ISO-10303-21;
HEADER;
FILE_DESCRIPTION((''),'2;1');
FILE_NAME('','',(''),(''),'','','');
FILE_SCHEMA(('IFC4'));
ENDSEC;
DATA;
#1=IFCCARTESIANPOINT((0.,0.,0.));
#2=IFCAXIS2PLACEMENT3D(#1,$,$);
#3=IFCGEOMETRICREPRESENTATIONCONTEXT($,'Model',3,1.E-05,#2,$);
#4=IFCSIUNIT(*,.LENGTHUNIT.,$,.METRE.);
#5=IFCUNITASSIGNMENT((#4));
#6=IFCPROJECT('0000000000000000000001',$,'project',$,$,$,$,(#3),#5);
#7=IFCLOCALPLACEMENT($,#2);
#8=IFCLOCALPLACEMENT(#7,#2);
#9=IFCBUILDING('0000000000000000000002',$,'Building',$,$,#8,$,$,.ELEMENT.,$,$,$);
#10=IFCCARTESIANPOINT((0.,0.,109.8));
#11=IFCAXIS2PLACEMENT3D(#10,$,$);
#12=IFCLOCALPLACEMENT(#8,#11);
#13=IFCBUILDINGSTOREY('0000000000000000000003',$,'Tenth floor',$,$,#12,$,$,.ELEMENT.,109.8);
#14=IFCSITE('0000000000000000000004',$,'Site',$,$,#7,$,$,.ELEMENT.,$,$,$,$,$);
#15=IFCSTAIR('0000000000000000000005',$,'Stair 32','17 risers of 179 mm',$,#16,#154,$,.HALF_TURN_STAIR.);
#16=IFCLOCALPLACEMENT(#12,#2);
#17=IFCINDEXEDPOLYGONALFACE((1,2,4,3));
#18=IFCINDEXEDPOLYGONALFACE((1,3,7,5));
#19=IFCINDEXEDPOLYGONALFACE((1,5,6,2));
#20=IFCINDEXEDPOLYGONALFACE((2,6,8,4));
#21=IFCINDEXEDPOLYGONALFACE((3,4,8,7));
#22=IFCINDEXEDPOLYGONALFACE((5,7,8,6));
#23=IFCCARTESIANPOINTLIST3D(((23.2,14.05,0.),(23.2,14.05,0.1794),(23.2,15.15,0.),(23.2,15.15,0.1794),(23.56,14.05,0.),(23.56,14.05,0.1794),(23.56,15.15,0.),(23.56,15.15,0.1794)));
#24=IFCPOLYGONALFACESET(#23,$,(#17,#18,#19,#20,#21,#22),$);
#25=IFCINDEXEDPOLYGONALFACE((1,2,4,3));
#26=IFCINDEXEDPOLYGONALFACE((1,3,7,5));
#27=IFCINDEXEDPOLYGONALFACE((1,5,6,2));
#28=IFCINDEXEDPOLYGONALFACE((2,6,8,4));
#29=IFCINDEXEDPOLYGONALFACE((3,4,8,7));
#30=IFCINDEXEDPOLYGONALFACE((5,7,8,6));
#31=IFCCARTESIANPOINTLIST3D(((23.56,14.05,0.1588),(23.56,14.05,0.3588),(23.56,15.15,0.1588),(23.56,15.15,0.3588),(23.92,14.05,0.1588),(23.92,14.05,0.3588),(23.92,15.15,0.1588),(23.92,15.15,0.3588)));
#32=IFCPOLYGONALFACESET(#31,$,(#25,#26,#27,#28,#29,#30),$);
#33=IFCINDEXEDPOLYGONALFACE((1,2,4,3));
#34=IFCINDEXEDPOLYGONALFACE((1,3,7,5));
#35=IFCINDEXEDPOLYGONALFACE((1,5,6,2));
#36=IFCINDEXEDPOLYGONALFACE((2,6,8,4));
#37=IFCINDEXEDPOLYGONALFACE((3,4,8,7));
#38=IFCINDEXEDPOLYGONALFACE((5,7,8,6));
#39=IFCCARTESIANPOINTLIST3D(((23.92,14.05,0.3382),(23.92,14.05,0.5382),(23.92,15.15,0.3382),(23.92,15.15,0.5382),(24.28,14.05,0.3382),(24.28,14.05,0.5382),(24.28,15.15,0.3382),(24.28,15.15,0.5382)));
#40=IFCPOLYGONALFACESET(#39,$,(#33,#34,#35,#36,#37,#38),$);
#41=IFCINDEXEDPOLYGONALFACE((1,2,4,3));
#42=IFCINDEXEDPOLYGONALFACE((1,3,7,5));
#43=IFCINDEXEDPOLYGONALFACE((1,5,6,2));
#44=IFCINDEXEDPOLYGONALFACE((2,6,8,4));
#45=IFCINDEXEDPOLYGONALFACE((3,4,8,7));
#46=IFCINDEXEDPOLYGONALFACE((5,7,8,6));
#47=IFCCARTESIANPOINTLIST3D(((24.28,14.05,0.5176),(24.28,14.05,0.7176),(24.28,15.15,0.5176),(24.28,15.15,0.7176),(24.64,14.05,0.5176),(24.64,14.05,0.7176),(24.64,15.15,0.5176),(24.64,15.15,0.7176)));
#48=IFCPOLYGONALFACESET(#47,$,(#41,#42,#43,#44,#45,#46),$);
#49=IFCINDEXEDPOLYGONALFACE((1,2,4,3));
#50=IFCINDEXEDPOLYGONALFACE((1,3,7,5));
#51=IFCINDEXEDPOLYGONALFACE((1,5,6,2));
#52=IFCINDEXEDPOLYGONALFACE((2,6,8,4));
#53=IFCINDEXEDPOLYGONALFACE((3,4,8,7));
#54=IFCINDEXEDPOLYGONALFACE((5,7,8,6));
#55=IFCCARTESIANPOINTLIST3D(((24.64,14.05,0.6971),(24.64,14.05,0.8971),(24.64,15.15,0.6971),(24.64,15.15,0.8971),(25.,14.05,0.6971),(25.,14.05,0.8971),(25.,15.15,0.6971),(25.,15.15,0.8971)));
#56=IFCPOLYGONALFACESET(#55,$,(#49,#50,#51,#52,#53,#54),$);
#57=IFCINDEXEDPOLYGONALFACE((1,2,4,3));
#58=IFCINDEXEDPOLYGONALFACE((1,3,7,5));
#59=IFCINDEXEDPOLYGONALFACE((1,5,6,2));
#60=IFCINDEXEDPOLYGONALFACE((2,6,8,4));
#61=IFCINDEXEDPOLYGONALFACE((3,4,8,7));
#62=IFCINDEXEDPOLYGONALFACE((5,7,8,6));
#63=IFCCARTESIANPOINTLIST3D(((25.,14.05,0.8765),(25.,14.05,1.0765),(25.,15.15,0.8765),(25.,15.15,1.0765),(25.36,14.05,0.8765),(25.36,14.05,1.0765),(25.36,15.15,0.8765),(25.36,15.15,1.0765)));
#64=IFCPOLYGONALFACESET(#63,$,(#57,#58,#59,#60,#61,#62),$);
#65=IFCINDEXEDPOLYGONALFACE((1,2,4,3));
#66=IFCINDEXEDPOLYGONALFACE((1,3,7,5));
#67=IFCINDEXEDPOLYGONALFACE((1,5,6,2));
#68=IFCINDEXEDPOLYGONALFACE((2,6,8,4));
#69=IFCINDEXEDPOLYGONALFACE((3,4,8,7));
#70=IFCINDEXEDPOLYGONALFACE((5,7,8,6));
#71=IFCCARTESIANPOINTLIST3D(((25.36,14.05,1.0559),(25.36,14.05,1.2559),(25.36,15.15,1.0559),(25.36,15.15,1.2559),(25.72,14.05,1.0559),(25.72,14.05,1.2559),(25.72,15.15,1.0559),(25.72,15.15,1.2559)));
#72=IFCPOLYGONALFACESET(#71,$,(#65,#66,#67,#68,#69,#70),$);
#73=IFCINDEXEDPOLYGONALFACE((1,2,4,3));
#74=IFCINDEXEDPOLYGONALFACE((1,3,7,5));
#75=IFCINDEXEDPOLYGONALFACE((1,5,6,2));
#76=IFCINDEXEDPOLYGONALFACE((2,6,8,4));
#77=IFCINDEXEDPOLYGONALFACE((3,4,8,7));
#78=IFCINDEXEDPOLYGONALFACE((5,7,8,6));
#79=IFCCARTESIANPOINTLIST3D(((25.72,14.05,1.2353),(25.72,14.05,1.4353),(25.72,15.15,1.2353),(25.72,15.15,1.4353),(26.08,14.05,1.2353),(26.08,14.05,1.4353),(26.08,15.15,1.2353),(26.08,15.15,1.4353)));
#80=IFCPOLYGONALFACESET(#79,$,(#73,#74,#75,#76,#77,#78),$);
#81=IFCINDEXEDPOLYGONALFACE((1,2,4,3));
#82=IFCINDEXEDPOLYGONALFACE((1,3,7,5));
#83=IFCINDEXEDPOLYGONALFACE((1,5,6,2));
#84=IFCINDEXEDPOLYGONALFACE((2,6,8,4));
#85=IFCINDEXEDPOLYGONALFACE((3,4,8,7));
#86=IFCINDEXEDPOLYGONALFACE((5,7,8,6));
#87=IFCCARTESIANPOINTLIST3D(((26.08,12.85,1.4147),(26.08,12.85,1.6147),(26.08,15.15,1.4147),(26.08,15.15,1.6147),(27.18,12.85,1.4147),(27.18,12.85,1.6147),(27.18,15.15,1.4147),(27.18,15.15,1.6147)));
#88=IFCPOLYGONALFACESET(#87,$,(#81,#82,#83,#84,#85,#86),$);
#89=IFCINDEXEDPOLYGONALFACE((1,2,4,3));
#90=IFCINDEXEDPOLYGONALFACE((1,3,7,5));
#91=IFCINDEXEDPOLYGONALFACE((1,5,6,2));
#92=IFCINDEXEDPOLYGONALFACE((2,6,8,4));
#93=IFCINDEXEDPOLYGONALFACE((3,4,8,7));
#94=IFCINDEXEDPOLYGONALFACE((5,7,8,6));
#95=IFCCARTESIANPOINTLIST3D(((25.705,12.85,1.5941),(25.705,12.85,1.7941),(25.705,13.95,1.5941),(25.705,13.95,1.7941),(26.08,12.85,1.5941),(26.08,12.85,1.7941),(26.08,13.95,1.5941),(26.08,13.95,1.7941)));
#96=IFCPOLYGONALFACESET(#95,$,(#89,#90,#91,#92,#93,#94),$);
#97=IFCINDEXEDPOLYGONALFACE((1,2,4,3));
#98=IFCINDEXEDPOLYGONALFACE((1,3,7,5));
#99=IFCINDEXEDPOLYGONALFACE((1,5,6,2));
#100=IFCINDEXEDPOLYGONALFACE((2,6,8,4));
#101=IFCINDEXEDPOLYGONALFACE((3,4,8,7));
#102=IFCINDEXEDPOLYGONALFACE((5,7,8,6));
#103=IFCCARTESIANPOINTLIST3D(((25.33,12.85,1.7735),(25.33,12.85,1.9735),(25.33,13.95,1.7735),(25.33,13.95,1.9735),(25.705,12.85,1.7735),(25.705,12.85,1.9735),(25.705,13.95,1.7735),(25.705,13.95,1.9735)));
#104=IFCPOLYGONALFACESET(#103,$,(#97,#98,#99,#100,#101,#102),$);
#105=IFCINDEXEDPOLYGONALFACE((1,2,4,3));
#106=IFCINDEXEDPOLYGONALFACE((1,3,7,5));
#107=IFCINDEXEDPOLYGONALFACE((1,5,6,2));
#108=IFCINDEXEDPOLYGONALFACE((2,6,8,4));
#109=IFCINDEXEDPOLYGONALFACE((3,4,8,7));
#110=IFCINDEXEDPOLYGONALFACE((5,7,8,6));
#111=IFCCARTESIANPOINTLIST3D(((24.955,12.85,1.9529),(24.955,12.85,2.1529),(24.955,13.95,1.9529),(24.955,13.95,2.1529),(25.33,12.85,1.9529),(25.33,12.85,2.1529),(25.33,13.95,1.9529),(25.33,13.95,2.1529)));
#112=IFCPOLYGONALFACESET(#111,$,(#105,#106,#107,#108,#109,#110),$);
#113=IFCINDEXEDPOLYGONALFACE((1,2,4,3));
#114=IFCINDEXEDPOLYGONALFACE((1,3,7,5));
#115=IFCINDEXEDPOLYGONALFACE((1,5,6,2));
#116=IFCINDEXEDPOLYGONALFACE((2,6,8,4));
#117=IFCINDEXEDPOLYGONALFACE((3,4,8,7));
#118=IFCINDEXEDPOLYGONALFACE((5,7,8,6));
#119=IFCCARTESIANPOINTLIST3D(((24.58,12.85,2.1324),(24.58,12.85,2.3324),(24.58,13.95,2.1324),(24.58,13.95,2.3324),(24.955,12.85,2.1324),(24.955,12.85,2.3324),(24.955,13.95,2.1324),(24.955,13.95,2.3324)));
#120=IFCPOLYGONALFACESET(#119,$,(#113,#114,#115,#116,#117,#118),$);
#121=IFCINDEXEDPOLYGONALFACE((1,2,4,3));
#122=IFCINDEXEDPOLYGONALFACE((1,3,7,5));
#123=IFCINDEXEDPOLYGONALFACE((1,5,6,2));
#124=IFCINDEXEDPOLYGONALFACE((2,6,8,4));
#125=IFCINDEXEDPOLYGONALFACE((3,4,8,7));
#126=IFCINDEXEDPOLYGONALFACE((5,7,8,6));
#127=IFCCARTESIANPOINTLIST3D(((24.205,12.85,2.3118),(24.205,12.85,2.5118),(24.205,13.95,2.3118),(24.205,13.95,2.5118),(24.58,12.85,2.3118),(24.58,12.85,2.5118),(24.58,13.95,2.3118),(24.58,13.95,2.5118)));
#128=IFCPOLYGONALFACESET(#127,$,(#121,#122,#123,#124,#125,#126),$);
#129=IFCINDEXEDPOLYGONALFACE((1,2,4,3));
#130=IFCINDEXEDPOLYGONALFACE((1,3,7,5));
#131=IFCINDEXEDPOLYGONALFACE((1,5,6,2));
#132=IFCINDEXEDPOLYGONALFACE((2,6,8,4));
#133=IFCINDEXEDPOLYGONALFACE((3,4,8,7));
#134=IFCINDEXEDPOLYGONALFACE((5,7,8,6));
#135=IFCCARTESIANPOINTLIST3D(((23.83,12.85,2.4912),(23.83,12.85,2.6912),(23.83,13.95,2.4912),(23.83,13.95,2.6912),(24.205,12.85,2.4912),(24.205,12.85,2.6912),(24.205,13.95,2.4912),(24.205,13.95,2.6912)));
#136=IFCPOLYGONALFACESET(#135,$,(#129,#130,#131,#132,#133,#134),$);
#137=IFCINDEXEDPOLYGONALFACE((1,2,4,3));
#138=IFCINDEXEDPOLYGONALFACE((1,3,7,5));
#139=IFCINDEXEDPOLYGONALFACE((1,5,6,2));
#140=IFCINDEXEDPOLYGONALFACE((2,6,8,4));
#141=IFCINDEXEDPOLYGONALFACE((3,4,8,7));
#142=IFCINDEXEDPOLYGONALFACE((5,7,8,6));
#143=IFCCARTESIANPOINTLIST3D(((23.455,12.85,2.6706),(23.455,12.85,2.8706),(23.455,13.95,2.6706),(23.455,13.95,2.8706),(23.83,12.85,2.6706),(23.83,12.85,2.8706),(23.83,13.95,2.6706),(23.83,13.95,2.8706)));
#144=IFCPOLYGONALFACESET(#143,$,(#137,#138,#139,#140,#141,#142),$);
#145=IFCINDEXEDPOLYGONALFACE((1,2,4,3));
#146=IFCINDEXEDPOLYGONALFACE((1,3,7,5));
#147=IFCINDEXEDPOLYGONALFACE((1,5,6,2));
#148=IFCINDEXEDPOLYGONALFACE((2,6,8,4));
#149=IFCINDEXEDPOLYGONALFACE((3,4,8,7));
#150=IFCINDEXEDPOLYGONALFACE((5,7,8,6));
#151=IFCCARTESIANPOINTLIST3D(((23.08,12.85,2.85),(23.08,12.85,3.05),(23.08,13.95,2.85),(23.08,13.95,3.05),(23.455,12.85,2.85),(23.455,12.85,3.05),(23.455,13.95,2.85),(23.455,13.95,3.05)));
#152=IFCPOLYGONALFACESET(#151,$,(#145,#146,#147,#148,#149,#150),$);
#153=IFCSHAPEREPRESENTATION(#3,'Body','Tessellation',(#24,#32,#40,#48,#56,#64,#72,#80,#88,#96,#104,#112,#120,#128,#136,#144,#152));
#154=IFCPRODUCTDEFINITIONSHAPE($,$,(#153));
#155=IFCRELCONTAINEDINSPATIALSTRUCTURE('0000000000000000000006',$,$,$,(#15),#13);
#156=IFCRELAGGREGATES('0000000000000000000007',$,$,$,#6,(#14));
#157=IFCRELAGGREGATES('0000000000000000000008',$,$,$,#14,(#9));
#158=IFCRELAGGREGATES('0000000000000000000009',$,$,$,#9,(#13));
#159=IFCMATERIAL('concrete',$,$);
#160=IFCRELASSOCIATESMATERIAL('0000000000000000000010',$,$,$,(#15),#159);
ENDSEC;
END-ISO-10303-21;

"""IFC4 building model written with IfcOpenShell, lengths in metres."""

from ifc_helpers import new_model, si_unit, frame, origin, place, context, project, spatial, polyline, outline, extrude, material, element, save


model = new_model("IFC4")

# Units and contexts
model_context = context("Model", 3, precision=1e-05, world=origin())
ifc_project = project(units=[si_unit("LENGTHUNIT", "METRE")], contexts=[model_context])

# Site, building, storey
site_placement = place(None, origin())
site = spatial("IfcSite", under=ifc_project, at=site_placement, Name="Site", CompositionType="ELEMENT")
building_placement = place(site_placement, origin())
building = spatial("IfcBuilding", under=site, at=building_placement, Name="Building", CompositionType="ELEMENT")
storey_placement = place(building_placement, frame((0.0, 0.0, 109.8)))
storey = spatial("IfcBuildingStorey", under=building, at=storey_placement, Name="Tenth floor", CompositionType="ELEMENT", Elevation=109.8)

# Shared definitions
ifc_material = material(Name="concrete")

# Stair
stair_placement = place(storey_placement, frame((23.2, 14.6, 0.0), z_axis=(0.0, 0.0, 1.0), x_axis=(1.0, 0.0, 0.0)))
element("IfcStair", 1, at=stair_placement, inside=storey, material=ifc_material, Name="Stair 32", Description="17 risers of 179 mm", PredefinedType="HALF_TURN_STAIR", context=model_context, shape_type="SweptSolid", body=[
    extrude(outline(polyline([(0.0, -0.55), (0.36, -0.55), (0.36, 0.55), (0.0, 0.55), (0.0, -0.55)])), origin(), (0.0, 0.0, 1.0), 0.1794),
    extrude(outline(polyline([(0.36, -0.55), (0.72, -0.55), (0.72, 0.55), (0.36, 0.55), (0.36, -0.55)])), frame((0.0, 0.0, 0.1588)), (0.0, 0.0, 1.0), 0.2),
    extrude(outline(polyline([(0.72, -0.55), (1.08, -0.55), (1.08, 0.55), (0.72, 0.55), (0.72, -0.55)])), frame((0.0, 0.0, 0.3382)), (0.0, 0.0, 1.0), 0.2),
    extrude(outline(polyline([(1.08, -0.55), (1.44, -0.55), (1.44, 0.55), (1.08, 0.55), (1.08, -0.55)])), frame((0.0, 0.0, 0.5176)), (0.0, 0.0, 1.0), 0.2),
    extrude(outline(polyline([(1.44, -0.55), (1.8, -0.55), (1.8, 0.55), (1.44, 0.55), (1.44, -0.55)])), frame((0.0, 0.0, 0.6971)), (0.0, 0.0, 1.0), 0.2),
    extrude(outline(polyline([(1.8, -0.55), (2.16, -0.55), (2.16, 0.55), (1.8, 0.55), (1.8, -0.55)])), frame((0.0, 0.0, 0.8765)), (0.0, 0.0, 1.0), 0.2),
    extrude(outline(polyline([(2.16, -0.55), (2.52, -0.55), (2.52, 0.55), (2.16, 0.55), (2.16, -0.55)])), frame((0.0, 0.0, 1.0559)), (0.0, 0.0, 1.0), 0.2),
    extrude(outline(polyline([(2.52, -0.55), (2.88, -0.55), (2.88, 0.55), (2.52, 0.55), (2.52, -0.55)])), frame((0.0, 0.0, 1.2353)), (0.0, 0.0, 1.0), 0.2),
    extrude(outline(polyline([(2.88, -1.75), (3.98, -1.75), (3.98, 0.55), (2.88, 0.55), (2.88, -1.75)])), frame((0.0, 0.0, 1.4147)), (0.0, 0.0, 1.0), 0.2),
    extrude(outline(polyline([(2.505, -1.75), (2.88, -1.75), (2.88, -0.65), (2.505, -0.65), (2.505, -1.75)])), frame((0.0, 0.0, 1.5941)), (0.0, 0.0, 1.0), 0.2),
    extrude(outline(polyline([(2.13, -1.75), (2.505, -1.75), (2.505, -0.65), (2.13, -0.65), (2.13, -1.75)])), frame((0.0, 0.0, 1.7735)), (0.0, 0.0, 1.0), 0.2),
    extrude(outline(polyline([(1.755, -1.75), (2.13, -1.75), (2.13, -0.65), (1.755, -0.65), (1.755, -1.75)])), frame((0.0, 0.0, 1.9529)), (0.0, 0.0, 1.0), 0.2),
    extrude(outline(polyline([(1.38, -1.75), (1.755, -1.75), (1.755, -0.65), (1.38, -0.65), (1.38, -1.75)])), frame((0.0, 0.0, 2.1324)), (0.0, 0.0, 1.0), 0.2),
    extrude(outline(polyline([(1.005, -1.75), (1.38, -1.75), (1.38, -0.65), (1.005, -0.65), (1.005, -1.75)])), frame((0.0, 0.0, 2.3118)), (0.0, 0.0, 1.0), 0.2),
    extrude(outline(polyline([(0.63, -1.75), (1.005, -1.75), (1.005, -0.65), (0.63, -0.65), (0.63, -1.75)])), frame((0.0, 0.0, 2.4912)), (0.0, 0.0, 1.0), 0.2),
    extrude(outline(polyline([(0.255, -1.75), (0.63, -1.75), (0.63, -0.65), (0.255, -0.65), (0.255, -1.75)])), frame((0.0, 0.0, 2.6706)), (0.0, 0.0, 1.0), 0.2),
    extrude(outline(polyline([(-0.12, -1.75), (0.255, -1.75), (0.255, -0.65), (-0.12, -0.65), (-0.12, -1.75)])), frame((0.0, 0.0, 2.85)), (0.0, 0.0, 1.0), 0.2),
])

save(model, "model.ifc")
